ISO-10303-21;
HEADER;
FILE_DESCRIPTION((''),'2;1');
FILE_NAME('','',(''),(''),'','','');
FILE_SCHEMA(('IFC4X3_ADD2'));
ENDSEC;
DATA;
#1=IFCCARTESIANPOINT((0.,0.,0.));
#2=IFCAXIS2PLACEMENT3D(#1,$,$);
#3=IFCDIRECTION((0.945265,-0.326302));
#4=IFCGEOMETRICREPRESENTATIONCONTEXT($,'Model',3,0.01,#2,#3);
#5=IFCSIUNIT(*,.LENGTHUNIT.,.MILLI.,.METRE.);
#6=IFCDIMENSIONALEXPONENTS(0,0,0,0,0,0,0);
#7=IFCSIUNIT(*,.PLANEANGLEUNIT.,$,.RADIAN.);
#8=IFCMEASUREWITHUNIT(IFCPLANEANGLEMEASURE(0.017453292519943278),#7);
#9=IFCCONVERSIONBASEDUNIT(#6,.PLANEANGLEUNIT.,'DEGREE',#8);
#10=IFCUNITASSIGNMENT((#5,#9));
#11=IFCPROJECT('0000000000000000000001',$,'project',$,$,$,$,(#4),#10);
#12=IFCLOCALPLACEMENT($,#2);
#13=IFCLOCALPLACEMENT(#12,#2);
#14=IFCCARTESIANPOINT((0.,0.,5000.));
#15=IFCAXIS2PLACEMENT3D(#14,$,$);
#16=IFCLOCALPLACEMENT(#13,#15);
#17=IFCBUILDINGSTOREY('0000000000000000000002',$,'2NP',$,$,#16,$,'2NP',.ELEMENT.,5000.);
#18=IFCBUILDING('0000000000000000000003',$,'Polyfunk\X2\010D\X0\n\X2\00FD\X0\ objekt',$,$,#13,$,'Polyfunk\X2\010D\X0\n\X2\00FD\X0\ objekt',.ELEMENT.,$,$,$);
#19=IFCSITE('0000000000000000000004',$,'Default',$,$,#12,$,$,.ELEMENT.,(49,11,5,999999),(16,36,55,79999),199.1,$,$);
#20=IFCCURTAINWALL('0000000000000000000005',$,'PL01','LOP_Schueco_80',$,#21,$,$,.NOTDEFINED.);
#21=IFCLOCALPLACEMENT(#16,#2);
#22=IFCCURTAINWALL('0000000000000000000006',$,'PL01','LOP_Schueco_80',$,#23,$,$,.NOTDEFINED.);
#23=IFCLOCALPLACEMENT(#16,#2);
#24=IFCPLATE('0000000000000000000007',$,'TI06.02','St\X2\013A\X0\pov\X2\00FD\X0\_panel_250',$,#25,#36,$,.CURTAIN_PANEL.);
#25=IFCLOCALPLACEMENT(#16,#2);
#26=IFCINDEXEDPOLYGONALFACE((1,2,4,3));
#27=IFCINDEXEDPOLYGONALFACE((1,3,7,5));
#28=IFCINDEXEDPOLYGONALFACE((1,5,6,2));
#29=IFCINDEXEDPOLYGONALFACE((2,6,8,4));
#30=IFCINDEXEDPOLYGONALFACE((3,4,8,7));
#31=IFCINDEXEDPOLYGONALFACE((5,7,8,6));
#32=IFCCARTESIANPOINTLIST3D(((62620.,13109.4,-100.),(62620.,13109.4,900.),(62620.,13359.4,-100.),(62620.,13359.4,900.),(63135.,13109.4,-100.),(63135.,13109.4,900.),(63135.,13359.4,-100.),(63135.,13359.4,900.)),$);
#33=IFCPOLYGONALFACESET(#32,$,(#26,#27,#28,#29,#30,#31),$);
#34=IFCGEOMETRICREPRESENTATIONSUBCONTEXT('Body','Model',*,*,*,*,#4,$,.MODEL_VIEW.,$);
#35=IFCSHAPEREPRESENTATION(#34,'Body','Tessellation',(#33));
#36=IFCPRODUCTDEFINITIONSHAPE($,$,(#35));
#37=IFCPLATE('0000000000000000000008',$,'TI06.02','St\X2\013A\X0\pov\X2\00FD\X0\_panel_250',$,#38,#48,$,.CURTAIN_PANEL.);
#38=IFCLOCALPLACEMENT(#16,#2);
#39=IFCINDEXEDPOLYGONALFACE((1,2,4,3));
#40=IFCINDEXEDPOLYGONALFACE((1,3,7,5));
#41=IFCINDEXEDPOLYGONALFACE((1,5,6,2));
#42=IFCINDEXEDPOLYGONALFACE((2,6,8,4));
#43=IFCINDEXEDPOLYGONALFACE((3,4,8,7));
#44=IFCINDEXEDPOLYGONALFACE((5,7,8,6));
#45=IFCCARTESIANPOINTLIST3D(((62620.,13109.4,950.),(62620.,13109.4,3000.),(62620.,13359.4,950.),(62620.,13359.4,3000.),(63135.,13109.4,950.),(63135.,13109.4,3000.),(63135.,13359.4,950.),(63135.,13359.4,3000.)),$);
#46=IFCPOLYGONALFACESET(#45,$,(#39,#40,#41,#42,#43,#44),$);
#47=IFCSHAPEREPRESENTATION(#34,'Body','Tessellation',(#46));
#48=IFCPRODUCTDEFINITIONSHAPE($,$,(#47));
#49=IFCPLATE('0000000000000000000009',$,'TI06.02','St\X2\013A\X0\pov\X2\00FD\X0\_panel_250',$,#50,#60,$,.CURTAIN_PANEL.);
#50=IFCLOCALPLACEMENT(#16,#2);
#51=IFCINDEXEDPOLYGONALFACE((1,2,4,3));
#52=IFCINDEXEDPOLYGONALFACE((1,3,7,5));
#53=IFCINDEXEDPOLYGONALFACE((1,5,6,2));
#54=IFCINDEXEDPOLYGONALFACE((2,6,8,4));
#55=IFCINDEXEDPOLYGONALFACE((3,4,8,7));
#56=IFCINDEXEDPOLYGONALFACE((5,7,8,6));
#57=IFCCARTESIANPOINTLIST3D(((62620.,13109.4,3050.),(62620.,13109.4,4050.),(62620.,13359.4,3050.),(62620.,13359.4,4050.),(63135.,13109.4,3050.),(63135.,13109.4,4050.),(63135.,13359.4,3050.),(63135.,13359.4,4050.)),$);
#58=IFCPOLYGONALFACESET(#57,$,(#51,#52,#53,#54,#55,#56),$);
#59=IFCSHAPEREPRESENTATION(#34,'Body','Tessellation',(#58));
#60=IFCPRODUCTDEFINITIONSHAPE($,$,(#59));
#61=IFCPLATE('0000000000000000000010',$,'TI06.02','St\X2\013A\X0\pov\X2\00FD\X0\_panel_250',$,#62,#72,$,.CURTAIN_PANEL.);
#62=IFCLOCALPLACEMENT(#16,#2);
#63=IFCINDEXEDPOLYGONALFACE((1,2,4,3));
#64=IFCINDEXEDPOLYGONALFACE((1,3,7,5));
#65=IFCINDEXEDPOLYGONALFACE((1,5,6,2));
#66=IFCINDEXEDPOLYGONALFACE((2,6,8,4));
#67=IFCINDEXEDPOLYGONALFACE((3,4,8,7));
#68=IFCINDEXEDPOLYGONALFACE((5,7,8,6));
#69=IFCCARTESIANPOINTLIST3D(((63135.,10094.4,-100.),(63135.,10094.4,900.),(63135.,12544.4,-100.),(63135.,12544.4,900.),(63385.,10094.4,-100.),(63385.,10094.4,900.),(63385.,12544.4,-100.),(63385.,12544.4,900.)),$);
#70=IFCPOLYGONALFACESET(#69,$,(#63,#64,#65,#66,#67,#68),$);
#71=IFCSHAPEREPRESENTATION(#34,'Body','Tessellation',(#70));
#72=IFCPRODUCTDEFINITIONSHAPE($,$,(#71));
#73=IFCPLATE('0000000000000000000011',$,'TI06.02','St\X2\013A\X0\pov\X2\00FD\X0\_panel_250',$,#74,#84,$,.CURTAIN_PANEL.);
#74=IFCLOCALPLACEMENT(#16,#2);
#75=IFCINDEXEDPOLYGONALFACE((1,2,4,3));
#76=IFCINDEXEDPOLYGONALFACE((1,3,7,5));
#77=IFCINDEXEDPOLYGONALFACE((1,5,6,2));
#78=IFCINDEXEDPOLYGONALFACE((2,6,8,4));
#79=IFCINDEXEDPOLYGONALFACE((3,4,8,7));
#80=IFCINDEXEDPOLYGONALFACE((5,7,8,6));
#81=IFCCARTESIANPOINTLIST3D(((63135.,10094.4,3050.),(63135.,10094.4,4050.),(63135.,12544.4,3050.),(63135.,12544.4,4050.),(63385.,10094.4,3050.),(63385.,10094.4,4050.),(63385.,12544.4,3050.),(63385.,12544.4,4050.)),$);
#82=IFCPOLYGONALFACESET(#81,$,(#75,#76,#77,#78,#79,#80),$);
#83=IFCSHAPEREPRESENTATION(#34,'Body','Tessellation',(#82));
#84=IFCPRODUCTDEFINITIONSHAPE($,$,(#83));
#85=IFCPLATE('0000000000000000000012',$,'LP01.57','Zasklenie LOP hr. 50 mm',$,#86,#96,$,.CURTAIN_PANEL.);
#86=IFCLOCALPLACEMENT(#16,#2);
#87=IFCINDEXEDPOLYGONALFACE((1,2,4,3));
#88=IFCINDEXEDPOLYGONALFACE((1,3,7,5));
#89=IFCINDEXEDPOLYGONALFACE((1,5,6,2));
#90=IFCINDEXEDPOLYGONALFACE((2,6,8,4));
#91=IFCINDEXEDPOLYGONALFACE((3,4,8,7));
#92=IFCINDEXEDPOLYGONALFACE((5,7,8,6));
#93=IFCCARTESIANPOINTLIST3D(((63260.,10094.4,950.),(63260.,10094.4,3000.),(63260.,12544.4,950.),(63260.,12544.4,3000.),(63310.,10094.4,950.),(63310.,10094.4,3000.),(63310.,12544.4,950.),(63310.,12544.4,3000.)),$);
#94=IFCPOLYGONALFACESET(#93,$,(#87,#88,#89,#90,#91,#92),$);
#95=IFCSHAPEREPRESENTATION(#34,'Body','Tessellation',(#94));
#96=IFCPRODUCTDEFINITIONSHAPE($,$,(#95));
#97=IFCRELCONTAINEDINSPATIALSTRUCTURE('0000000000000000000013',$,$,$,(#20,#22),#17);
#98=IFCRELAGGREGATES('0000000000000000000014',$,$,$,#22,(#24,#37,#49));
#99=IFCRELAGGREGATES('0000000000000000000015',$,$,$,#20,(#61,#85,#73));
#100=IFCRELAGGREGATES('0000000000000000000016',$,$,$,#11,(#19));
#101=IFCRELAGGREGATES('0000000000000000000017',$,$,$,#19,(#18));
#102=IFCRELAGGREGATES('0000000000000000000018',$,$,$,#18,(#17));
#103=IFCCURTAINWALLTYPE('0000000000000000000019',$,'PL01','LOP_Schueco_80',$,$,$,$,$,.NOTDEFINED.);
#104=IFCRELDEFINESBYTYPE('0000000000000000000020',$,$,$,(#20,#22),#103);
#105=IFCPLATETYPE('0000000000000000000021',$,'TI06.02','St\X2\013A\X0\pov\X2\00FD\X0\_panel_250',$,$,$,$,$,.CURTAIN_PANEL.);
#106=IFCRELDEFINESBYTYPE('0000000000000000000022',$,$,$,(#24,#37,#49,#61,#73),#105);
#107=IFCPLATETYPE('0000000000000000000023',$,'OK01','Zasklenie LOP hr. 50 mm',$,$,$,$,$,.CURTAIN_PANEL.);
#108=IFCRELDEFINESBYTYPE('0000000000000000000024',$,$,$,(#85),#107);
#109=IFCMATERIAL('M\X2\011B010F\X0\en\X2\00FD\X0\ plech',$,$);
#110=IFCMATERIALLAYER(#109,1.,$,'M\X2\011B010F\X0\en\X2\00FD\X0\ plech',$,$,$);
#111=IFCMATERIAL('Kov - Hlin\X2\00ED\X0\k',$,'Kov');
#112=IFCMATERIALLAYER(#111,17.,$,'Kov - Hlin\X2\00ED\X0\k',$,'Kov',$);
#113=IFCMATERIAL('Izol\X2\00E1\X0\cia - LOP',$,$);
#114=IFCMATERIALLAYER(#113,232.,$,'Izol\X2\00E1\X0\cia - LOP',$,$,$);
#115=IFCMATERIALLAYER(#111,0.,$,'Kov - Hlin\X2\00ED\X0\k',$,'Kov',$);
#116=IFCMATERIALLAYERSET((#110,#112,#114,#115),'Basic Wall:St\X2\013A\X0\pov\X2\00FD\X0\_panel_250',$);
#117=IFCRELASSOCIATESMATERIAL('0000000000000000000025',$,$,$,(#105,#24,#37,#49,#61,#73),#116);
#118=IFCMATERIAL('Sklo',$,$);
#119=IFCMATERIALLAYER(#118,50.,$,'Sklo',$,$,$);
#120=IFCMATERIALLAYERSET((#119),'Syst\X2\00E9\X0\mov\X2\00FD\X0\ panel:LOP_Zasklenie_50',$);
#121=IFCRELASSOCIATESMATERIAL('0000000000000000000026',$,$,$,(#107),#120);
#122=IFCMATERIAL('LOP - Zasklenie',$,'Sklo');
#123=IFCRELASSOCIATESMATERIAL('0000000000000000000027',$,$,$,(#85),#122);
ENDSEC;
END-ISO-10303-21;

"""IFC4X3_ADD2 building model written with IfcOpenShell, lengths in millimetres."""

from ifc_helpers import new_model, entity, si_unit, converted_unit, direction, frame, frame_2d, origin, origin_2d_with_axis, place, context, subcontext, project, spatial, rectangle, extrude, source, transform, mapped, material, layer, layer_set, layer_usage, type_object, type_shapes, element, aggregate, save


model = new_model("IFC4X3_ADD2")

# Units and contexts
model_context = context("Model", 3, precision=0.01, world=origin(), true_north=direction((0.945265, -0.326302)))
body_context = subcontext(model_context, "Body", "Model", "MODEL_VIEW")
ifc_project = project(units=[si_unit("LENGTHUNIT", "METRE", prefix="MILLI"), converted_unit("PLANEANGLEUNIT", "DEGREE", entity("IfcPlaneAngleMeasure", 0.017453292519943278), si_unit("PLANEANGLEUNIT", "RADIAN"), dimensions=[0, 0, 0, 0, 0, 0, 0])], contexts=[model_context])

# Site, building, storey
site_placement = place(None, origin())
site = spatial("IfcSite", under=ifc_project, at=site_placement, Name="Default", CompositionType="ELEMENT", RefLatitude=(49, 11, 5, 999999), RefLongitude=(16, 36, 55, 79999), RefElevation=199.1)
building_placement = place(site_placement, origin())
building = spatial("IfcBuilding", under=site, at=building_placement, Name="Polyfunkčný objekt", LongName="Polyfunkčný objekt", CompositionType="ELEMENT")
storey_placement = place(building_placement, frame((0.0, 0.0, 5000.0)))
storey = spatial("IfcBuildingStorey", under=building, at=storey_placement, Name="2NP", LongName="2NP", CompositionType="ELEMENT", Elevation=5000.0)

# Curtain wall
curtain_wall_type = type_object("IfcCurtainWallType", Name="PL01", Description="LOP_Schueco_80", PredefinedType="NOTDEFINED")
curtain_wall_1_placement = place(storey_placement, frame((0.0, 0.0, -5000.0)))
curtain_wall_1 = element("IfcCurtainWall", 1, at=curtain_wall_1_placement, inside=storey, type_object=curtain_wall_type, Name="PL01", Description="LOP_Schueco_80", PredefinedType="NOTDEFINED")

# Curtain wall
curtain_wall_2_placement = place(storey_placement, frame((0.0, 0.0, -5000.0)))
curtain_wall_2 = element("IfcCurtainWall", 2, at=curtain_wall_2_placement, inside=storey, type_object=curtain_wall_type, Name="PL01", Description="LOP_Schueco_80", PredefinedType="NOTDEFINED")

# Plates
ifc_material_1 = material(Name="Měďený plech")
ifc_layer_1 = layer(ifc_material_1, 1.0, Name="Měďený plech")
ifc_material_2 = material(Name="Kov - Hliník", Category="Kov")
ifc_layer_2 = layer(ifc_material_2, 17.0, Name="Kov - Hliník", Category="Kov")
ifc_material_3 = material(Name="Izolácia - LOP")
ifc_layer_3 = layer(ifc_material_3, 232.0, Name="Izolácia - LOP")
ifc_layer_4 = layer(ifc_material_2, 0.0, Name="Kov - Hliník", Category="Kov")
ifc_layer_set_1 = layer_set([ifc_layer_1, ifc_layer_2, ifc_layer_3, ifc_layer_4], Name="Basic Wall:Stĺpový_panel_250")
ifc_layer_usage_1 = layer_usage(ifc_layer_set_1, "AXIS2", "NEGATIVE", 125.0)
plate_type_1 = type_object("IfcPlateType", Name="TI06.02", Description="Stĺpový_panel_250", PredefinedType="CURTAIN_PANEL", material=ifc_layer_set_1)
plate_1_placement = place(storey_placement, frame((62620.0, 13234.4, -100.0)))
plate_1 = element("IfcPlate", 3, at=plate_1_placement, type_object=plate_type_1, material=ifc_layer_usage_1, Name="TI06.02", Description="Stĺpový_panel_250", PredefinedType="CURTAIN_PANEL", context=body_context, shape_type="SweptSolid", body=[
    extrude(rectangle(XDim=250.0, YDim=515.0, at=frame_2d((0.0, 0.0), x_axis=(1.0, 0.0))), frame((257.5, 0.0, 0.0), z_axis=(0.0, 0.0, 1.0), x_axis=(0.0, 1.0, 0.0)), (0.0, 0.0, 1.0), 1000.0),
])
ifc_layer_usage_2 = layer_usage(ifc_layer_set_1, "AXIS2", "NEGATIVE", 125.0)
plate_2_placement = place(storey_placement, frame((62620.0, 13234.4, 950.0)))
plate_2 = element("IfcPlate", 4, at=plate_2_placement, type_object=plate_type_1, material=ifc_layer_usage_2, Name="TI06.02", Description="Stĺpový_panel_250", PredefinedType="CURTAIN_PANEL", context=body_context, shape_type="SweptSolid", body=[
    extrude(rectangle(XDim=250.0, YDim=515.0, at=frame_2d((0.0, 0.0), x_axis=(1.0, 0.0))), frame((257.5, 0.0, 0.0), z_axis=(0.0, 0.0, 1.0), x_axis=(0.0, 1.0, 0.0)), (0.0, 0.0, 1.0), 2050.0),
])
ifc_layer_usage_3 = layer_usage(ifc_layer_set_1, "AXIS2", "NEGATIVE", 125.0)
plate_3_placement = place(storey_placement, frame((62620.0, 13234.4, 3050.0)))
plate_3 = element("IfcPlate", 5, at=plate_3_placement, type_object=plate_type_1, material=ifc_layer_usage_3, Name="TI06.02", Description="Stĺpový_panel_250", PredefinedType="CURTAIN_PANEL", context=body_context, shape_type="SweptSolid", body=[
    extrude(rectangle(XDim=250.0, YDim=515.0, at=frame_2d((0.0, 0.0), x_axis=(1.0, 0.0))), frame((257.5, 0.0, 0.0), z_axis=(0.0, 0.0, 1.0), x_axis=(0.0, 1.0, 0.0)), (0.0, 0.0, 1.0), 1000.0),
])
aggregate(curtain_wall_2, [plate_1, plate_2, plate_3])
ifc_layer_usage_4 = layer_usage(ifc_layer_set_1, "AXIS2", "NEGATIVE", 125.0)
plate_4_placement = place(storey_placement, frame((63260.0, 12544.4, -100.0), z_axis=(0.0, 0.0, 1.0), x_axis=(0.0, -1.0, 0.0)))
plate_4 = element("IfcPlate", 6, at=plate_4_placement, type_object=plate_type_1, material=ifc_layer_usage_4, Name="TI06.02", Description="Stĺpový_panel_250", PredefinedType="CURTAIN_PANEL", context=body_context, shape_type="SweptSolid", body=[
    extrude(rectangle(XDim=250.0, YDim=2450.0, at=frame_2d((0.0, 0.0), x_axis=(1.0, 0.0))), frame((1225.0, 0.0, 0.0), z_axis=(0.0, 0.0, 1.0), x_axis=(0.0, 1.0, 0.0)), (0.0, 0.0, 1.0), 1000.0),
])
ifc_layer_usage_5 = layer_usage(ifc_layer_set_1, "AXIS2", "NEGATIVE", 125.0)
plate_5_placement = place(storey_placement, frame((63260.0, 12544.4, 3050.0), z_axis=(0.0, 0.0, 1.0), x_axis=(0.0, -1.0, 0.0)))
plate_5 = element("IfcPlate", 7, at=plate_5_placement, type_object=plate_type_1, material=ifc_layer_usage_5, Name="TI06.02", Description="Stĺpový_panel_250", PredefinedType="CURTAIN_PANEL", context=body_context, shape_type="SweptSolid", body=[
    extrude(rectangle(XDim=250.0, YDim=2450.0, at=frame_2d((0.0, 0.0), x_axis=(1.0, 0.0))), frame((1225.0, 0.0, 0.0), z_axis=(0.0, 0.0, 1.0), x_axis=(0.0, 1.0, 0.0)), (0.0, 0.0, 1.0), 1000.0),
])
ifc_material_4 = material(Name="LOP - Zasklenie", Category="Sklo")
ifc_material_5 = material(Name="Sklo")
ifc_layer_5 = layer(ifc_material_5, 50.0, Name="Sklo")
ifc_layer_set_2 = layer_set([ifc_layer_5], Name="Systémový panel:LOP_Zasklenie_50")
plate_type_2 = type_object("IfcPlateType", Name="OK01", Description="Zasklenie LOP hr. 50 mm", PredefinedType="CURTAIN_PANEL", material=ifc_layer_set_2)
shared_shape_1 = source(origin(), body_context, "Body", "SweptSolid", [
    extrude(rectangle(XDim=50.0, YDim=2450.0, at=origin_2d_with_axis()), frame((0.0, 25.0, 0.0), z_axis=(0.0, 0.0, 1.0), x_axis=(0.0, 1.0, 0.0)), (0.0, 0.0, 1.0), 2050.0),
])
type_shapes(plate_type_2, [shared_shape_1])
plate_6_placement = place(curtain_wall_1_placement, frame((63260.0, 11319.4, 5950.0), z_axis=(0.0, 0.0, 1.0), x_axis=(0.0, -1.0, 0.0)))
plate_6 = element("IfcPlate", 8, at=plate_6_placement, type_object=plate_type_2, material=ifc_material_4, Name="LP01.57", Description="Zasklenie LOP hr. 50 mm", PredefinedType="CURTAIN_PANEL", context=body_context, shape_type="MappedRepresentation", body=[
    mapped(shared_shape_1, transform((0.0, 0.0, 0.0), scale=1.0)),
])
aggregate(curtain_wall_1, [plate_4, plate_6, plate_5])

save(model, "model.ifc")
